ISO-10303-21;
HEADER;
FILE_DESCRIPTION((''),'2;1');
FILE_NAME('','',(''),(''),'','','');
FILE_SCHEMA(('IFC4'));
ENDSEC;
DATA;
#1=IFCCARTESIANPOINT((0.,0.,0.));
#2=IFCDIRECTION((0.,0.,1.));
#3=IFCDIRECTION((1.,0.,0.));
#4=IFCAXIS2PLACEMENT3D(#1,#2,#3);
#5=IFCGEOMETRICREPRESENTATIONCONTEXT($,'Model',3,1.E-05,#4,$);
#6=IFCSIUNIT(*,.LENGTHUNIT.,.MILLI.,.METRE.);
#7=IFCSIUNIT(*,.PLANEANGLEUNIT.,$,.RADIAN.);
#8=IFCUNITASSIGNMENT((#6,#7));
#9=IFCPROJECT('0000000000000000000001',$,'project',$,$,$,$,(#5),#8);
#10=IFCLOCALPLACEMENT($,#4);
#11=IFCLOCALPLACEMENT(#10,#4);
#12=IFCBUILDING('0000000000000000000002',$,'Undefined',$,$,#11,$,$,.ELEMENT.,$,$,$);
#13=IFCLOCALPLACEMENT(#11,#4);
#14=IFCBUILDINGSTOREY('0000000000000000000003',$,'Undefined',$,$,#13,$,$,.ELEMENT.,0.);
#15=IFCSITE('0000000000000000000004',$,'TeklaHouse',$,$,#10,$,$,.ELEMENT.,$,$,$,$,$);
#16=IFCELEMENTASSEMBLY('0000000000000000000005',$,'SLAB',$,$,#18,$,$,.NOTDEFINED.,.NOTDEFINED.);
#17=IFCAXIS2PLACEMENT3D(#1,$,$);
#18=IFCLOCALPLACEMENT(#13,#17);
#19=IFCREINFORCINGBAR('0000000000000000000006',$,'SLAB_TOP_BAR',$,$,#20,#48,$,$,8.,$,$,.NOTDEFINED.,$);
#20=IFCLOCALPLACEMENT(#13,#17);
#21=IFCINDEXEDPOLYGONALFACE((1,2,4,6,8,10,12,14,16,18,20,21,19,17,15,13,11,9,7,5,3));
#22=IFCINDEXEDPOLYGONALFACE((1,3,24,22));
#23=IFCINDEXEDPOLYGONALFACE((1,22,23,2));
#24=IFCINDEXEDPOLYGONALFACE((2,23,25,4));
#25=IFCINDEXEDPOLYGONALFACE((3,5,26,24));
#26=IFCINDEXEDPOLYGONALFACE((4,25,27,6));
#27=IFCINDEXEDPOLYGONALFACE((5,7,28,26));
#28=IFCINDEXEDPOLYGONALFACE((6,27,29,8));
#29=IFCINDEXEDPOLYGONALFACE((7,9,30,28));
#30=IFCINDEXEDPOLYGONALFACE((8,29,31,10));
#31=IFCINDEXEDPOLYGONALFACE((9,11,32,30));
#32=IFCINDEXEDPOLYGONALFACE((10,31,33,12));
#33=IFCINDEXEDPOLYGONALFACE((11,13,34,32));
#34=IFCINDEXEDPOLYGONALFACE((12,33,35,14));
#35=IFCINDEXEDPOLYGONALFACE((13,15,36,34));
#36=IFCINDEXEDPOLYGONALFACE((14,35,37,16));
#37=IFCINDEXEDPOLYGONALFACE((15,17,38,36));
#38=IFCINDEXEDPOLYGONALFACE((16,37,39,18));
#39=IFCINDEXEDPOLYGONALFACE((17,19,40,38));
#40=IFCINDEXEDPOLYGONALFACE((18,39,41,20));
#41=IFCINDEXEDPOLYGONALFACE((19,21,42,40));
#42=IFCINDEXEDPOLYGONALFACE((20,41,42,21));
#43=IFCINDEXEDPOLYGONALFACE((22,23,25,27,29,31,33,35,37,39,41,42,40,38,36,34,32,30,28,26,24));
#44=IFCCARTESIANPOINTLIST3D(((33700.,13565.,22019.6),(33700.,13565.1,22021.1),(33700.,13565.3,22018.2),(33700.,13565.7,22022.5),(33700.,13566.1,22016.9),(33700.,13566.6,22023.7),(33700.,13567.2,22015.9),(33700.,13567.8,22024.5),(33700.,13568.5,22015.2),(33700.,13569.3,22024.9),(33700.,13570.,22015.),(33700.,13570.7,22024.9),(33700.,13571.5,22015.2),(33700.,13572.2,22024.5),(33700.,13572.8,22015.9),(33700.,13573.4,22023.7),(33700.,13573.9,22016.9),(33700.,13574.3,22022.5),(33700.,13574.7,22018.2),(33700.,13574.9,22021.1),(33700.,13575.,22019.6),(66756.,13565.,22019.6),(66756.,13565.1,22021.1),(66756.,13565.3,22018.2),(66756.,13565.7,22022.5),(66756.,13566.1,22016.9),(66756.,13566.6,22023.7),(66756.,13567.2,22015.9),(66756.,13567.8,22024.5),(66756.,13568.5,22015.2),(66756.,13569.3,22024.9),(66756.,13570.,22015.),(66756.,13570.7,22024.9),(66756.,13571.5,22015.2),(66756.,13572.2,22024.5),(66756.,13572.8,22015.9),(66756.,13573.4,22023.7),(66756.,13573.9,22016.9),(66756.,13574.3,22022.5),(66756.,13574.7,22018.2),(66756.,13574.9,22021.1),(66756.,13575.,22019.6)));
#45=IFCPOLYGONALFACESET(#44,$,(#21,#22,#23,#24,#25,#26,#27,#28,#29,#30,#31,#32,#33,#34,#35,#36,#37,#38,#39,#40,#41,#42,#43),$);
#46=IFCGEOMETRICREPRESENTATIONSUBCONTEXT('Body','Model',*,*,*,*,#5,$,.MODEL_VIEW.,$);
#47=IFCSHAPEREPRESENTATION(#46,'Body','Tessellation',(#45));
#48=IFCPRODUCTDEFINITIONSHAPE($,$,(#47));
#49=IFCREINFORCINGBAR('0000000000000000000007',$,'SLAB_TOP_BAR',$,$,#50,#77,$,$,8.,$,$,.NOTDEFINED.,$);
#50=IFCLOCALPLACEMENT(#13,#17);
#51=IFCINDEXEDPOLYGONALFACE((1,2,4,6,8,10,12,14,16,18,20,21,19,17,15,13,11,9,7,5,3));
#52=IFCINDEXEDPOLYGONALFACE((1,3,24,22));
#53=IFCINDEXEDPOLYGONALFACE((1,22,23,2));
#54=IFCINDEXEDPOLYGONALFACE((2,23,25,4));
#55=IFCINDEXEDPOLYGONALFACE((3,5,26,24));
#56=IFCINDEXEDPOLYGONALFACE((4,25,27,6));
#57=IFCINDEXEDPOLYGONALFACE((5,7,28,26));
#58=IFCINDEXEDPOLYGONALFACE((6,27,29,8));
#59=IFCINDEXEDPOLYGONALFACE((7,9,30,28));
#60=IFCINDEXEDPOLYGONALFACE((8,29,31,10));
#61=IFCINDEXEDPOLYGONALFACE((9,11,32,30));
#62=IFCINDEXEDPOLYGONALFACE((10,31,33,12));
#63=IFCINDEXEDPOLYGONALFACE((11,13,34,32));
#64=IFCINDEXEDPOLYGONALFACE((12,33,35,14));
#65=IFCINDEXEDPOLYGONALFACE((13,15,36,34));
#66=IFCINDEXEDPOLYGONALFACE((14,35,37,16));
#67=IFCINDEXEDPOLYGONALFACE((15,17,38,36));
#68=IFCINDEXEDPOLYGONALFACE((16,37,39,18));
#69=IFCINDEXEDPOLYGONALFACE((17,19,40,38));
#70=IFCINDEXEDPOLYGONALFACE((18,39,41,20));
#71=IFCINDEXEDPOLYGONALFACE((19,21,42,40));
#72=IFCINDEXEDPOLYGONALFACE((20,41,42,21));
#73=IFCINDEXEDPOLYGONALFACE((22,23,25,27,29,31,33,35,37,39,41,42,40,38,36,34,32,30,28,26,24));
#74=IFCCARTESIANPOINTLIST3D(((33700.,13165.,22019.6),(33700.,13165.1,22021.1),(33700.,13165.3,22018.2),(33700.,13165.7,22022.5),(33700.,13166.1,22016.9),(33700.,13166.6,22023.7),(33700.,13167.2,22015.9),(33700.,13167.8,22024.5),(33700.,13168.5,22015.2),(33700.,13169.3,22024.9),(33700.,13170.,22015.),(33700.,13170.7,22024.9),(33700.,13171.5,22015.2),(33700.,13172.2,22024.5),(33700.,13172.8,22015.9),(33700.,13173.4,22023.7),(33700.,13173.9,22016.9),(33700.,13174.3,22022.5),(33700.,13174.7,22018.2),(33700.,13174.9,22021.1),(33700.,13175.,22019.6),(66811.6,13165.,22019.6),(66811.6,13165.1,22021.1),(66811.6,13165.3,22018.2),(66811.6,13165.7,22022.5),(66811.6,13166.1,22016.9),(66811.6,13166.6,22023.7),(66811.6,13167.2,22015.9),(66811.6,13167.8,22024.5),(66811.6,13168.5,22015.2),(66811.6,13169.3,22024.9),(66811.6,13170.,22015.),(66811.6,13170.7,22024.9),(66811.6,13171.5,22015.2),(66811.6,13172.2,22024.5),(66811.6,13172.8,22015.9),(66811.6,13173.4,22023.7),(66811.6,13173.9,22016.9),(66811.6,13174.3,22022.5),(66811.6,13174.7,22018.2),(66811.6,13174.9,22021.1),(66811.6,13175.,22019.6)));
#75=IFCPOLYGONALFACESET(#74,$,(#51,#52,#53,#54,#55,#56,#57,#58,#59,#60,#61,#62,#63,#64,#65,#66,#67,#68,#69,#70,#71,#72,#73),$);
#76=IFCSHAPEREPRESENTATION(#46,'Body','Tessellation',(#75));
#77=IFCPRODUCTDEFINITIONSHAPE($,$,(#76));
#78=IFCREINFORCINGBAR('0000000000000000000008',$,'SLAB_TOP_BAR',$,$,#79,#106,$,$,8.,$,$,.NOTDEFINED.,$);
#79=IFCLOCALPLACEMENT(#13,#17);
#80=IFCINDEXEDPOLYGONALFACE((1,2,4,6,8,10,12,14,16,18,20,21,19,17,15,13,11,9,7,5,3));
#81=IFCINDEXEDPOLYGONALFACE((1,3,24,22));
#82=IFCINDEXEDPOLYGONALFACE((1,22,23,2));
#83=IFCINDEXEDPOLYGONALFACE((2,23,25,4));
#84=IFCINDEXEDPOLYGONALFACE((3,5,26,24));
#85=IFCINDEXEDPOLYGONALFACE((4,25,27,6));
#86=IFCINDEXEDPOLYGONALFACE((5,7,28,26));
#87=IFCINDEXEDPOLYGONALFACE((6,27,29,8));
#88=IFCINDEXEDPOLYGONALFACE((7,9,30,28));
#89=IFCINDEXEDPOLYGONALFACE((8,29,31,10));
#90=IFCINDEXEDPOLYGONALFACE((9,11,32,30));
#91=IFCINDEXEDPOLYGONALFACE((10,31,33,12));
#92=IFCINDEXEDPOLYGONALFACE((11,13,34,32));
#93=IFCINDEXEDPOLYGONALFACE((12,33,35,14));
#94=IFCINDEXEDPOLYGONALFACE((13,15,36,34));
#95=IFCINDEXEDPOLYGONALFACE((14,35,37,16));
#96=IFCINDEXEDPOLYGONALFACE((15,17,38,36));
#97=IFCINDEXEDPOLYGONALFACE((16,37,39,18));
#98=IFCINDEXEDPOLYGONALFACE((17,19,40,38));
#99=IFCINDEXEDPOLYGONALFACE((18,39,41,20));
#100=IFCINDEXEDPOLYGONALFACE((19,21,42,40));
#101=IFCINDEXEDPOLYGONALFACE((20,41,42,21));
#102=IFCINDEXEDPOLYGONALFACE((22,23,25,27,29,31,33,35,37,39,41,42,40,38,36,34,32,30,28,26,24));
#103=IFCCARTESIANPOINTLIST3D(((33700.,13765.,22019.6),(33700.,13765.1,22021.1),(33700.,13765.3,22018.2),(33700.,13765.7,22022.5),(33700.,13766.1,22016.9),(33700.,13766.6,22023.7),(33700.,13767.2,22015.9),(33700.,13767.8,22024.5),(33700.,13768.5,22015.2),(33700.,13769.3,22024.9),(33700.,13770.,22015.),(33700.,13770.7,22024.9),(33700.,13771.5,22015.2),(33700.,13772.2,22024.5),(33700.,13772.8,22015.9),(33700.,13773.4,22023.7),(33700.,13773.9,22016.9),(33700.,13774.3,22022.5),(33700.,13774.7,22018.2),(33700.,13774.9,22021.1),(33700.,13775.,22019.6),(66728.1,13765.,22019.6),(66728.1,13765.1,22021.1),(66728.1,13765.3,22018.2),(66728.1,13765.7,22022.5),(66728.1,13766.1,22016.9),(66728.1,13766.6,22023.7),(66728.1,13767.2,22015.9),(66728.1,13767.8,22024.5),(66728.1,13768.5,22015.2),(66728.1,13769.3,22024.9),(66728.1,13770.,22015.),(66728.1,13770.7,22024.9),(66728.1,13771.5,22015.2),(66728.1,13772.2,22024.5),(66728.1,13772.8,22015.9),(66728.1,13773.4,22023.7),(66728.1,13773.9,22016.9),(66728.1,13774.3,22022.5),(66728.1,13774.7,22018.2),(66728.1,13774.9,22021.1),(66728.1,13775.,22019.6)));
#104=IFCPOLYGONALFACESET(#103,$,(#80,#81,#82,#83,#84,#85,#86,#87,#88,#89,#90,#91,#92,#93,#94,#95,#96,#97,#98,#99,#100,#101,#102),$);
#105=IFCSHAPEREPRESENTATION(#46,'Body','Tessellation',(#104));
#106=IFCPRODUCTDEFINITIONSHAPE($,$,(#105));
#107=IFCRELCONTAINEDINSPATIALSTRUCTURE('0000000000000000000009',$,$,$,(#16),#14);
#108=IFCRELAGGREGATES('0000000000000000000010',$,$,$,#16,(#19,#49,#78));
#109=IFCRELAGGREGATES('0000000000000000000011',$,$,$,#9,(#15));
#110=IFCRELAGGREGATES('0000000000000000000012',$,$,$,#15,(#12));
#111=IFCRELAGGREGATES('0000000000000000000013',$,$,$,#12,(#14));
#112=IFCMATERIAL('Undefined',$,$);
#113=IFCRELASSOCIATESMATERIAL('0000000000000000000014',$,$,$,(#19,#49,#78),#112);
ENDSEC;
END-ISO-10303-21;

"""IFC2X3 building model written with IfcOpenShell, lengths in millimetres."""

from ifc_helpers import new_model, entity, si_unit, frame, origin_with_axes, place, context, subcontext, project, spatial, source, transform, mapped, material, element, aggregate, save


model = new_model("IFC2X3")

# Units and contexts
model_context = context("Model", 3, precision=1e-05, world=origin_with_axes())
body_context = subcontext(model_context, "Body", "Model", "MODEL_VIEW")
ifc_project = project(units=[si_unit("LENGTHUNIT", "METRE", prefix="MILLI"), si_unit("PLANEANGLEUNIT", "RADIAN")], contexts=[model_context])

# Site, building, storey
site_placement = place(None, origin_with_axes())
site = spatial("IfcSite", under=ifc_project, at=site_placement, Name="TeklaHouse", CompositionType="ELEMENT")
building_placement = place(site_placement, origin_with_axes())
building = spatial("IfcBuilding", under=site, at=building_placement, Name="Undefined", CompositionType="ELEMENT")
storey_placement = place(building_placement, origin_with_axes())
storey = spatial("IfcBuildingStorey", under=building, at=storey_placement, Name="Undefined", CompositionType="ELEMENT", Elevation=0.0)

# Shared definitions
ifc_material_1 = material(Name="Undefined")

# Element assembly, reinforcing bars
assembly_1_placement = place(storey_placement, origin_with_axes())
assembly_1 = element("IfcElementAssembly", 1, at=assembly_1_placement, inside=storey, Name="SLAB", AssemblyPlace="NOTDEFINED", PredefinedType="NOTDEFINED")
shared_shape_1 = source(origin_with_axes(), body_context, "Body", "AdvancedSweptSolid", [
    entity("IfcSweptDiskSolid", entity("IfcTrimmedCurve", entity("IfcLine", entity("IfcCartesianPoint", [0.0, 0.0, 0.0]), entity("IfcVector", entity("IfcDirection", [1.0, 0.0, 0.0]), 1.0)), [entity("IfcParameterValue", 0.0)], [entity("IfcParameterValue", 33055.953575)], True, "PARAMETER"), 5.0, None, 0.0, 33056.0),
])
reinforcing_bar_1_placement = place(assembly_1_placement, frame((66756.0, 13570.0, 22020.0), z_axis=(0.0, 0.0, -1.0), x_axis=(-1.0, 0.0, 0.0)))
reinforcing_bar_1 = element("IfcReinforcingBar", 2, at=reinforcing_bar_1_placement, material=ifc_material_1, Name="SLAB_TOP_BAR", BarRole="NOTDEFINED", NominalDiameter=8.0, context=body_context, shape_type="MappedRepresentation", body=[
    mapped(shared_shape_1, transform((0.0, 0.0, 0.0))),
])
shared_shape_2 = source(origin_with_axes(), body_context, "Body", "AdvancedSweptSolid", [
    entity("IfcSweptDiskSolid", entity("IfcTrimmedCurve", entity("IfcLine", entity("IfcCartesianPoint", [0.0, 0.0, 0.0]), entity("IfcVector", entity("IfcDirection", [1.0, 0.0, 0.0]), 1.0)), [entity("IfcParameterValue", 0.0)], [entity("IfcParameterValue", 33111.646501)], True, "PARAMETER"), 5.0, None, 0.0, 33111.6),
])
reinforcing_bar_2_placement = place(assembly_1_placement, frame((66811.6, 13170.0, 22020.0), z_axis=(0.0, 0.0, -1.0), x_axis=(-1.0, 0.0, 0.0)))
reinforcing_bar_2 = element("IfcReinforcingBar", 3, at=reinforcing_bar_2_placement, material=ifc_material_1, Name="SLAB_TOP_BAR", BarRole="NOTDEFINED", NominalDiameter=8.0, context=body_context, shape_type="MappedRepresentation", body=[
    mapped(shared_shape_2, transform((0.0, 0.0, 0.0))),
])
shared_shape_3 = source(origin_with_axes(), body_context, "Body", "AdvancedSweptSolid", [
    entity("IfcSweptDiskSolid", entity("IfcTrimmedCurve", entity("IfcLine", entity("IfcCartesianPoint", [0.0, 0.0, 0.0]), entity("IfcVector", entity("IfcDirection", [1.0, 0.0, 0.0]), 1.0)), [entity("IfcParameterValue", 0.0)], [entity("IfcParameterValue", 33028.107111)], True, "PARAMETER"), 5.0, None, 0.0, 33028.1),
])
reinforcing_bar_3_placement = place(assembly_1_placement, frame((66728.1, 13770.0, 22020.0), z_axis=(0.0, 0.0, -1.0), x_axis=(-1.0, 0.0, 0.0)))
reinforcing_bar_3 = element("IfcReinforcingBar", 4, at=reinforcing_bar_3_placement, material=ifc_material_1, Name="SLAB_TOP_BAR", BarRole="NOTDEFINED", NominalDiameter=8.0, context=body_context, shape_type="MappedRepresentation", body=[
    mapped(shared_shape_3, transform((0.0, 0.0, 0.0))),
])
aggregate(assembly_1, [reinforcing_bar_1, reinforcing_bar_2, reinforcing_bar_3])

save(model, "model.ifc")
